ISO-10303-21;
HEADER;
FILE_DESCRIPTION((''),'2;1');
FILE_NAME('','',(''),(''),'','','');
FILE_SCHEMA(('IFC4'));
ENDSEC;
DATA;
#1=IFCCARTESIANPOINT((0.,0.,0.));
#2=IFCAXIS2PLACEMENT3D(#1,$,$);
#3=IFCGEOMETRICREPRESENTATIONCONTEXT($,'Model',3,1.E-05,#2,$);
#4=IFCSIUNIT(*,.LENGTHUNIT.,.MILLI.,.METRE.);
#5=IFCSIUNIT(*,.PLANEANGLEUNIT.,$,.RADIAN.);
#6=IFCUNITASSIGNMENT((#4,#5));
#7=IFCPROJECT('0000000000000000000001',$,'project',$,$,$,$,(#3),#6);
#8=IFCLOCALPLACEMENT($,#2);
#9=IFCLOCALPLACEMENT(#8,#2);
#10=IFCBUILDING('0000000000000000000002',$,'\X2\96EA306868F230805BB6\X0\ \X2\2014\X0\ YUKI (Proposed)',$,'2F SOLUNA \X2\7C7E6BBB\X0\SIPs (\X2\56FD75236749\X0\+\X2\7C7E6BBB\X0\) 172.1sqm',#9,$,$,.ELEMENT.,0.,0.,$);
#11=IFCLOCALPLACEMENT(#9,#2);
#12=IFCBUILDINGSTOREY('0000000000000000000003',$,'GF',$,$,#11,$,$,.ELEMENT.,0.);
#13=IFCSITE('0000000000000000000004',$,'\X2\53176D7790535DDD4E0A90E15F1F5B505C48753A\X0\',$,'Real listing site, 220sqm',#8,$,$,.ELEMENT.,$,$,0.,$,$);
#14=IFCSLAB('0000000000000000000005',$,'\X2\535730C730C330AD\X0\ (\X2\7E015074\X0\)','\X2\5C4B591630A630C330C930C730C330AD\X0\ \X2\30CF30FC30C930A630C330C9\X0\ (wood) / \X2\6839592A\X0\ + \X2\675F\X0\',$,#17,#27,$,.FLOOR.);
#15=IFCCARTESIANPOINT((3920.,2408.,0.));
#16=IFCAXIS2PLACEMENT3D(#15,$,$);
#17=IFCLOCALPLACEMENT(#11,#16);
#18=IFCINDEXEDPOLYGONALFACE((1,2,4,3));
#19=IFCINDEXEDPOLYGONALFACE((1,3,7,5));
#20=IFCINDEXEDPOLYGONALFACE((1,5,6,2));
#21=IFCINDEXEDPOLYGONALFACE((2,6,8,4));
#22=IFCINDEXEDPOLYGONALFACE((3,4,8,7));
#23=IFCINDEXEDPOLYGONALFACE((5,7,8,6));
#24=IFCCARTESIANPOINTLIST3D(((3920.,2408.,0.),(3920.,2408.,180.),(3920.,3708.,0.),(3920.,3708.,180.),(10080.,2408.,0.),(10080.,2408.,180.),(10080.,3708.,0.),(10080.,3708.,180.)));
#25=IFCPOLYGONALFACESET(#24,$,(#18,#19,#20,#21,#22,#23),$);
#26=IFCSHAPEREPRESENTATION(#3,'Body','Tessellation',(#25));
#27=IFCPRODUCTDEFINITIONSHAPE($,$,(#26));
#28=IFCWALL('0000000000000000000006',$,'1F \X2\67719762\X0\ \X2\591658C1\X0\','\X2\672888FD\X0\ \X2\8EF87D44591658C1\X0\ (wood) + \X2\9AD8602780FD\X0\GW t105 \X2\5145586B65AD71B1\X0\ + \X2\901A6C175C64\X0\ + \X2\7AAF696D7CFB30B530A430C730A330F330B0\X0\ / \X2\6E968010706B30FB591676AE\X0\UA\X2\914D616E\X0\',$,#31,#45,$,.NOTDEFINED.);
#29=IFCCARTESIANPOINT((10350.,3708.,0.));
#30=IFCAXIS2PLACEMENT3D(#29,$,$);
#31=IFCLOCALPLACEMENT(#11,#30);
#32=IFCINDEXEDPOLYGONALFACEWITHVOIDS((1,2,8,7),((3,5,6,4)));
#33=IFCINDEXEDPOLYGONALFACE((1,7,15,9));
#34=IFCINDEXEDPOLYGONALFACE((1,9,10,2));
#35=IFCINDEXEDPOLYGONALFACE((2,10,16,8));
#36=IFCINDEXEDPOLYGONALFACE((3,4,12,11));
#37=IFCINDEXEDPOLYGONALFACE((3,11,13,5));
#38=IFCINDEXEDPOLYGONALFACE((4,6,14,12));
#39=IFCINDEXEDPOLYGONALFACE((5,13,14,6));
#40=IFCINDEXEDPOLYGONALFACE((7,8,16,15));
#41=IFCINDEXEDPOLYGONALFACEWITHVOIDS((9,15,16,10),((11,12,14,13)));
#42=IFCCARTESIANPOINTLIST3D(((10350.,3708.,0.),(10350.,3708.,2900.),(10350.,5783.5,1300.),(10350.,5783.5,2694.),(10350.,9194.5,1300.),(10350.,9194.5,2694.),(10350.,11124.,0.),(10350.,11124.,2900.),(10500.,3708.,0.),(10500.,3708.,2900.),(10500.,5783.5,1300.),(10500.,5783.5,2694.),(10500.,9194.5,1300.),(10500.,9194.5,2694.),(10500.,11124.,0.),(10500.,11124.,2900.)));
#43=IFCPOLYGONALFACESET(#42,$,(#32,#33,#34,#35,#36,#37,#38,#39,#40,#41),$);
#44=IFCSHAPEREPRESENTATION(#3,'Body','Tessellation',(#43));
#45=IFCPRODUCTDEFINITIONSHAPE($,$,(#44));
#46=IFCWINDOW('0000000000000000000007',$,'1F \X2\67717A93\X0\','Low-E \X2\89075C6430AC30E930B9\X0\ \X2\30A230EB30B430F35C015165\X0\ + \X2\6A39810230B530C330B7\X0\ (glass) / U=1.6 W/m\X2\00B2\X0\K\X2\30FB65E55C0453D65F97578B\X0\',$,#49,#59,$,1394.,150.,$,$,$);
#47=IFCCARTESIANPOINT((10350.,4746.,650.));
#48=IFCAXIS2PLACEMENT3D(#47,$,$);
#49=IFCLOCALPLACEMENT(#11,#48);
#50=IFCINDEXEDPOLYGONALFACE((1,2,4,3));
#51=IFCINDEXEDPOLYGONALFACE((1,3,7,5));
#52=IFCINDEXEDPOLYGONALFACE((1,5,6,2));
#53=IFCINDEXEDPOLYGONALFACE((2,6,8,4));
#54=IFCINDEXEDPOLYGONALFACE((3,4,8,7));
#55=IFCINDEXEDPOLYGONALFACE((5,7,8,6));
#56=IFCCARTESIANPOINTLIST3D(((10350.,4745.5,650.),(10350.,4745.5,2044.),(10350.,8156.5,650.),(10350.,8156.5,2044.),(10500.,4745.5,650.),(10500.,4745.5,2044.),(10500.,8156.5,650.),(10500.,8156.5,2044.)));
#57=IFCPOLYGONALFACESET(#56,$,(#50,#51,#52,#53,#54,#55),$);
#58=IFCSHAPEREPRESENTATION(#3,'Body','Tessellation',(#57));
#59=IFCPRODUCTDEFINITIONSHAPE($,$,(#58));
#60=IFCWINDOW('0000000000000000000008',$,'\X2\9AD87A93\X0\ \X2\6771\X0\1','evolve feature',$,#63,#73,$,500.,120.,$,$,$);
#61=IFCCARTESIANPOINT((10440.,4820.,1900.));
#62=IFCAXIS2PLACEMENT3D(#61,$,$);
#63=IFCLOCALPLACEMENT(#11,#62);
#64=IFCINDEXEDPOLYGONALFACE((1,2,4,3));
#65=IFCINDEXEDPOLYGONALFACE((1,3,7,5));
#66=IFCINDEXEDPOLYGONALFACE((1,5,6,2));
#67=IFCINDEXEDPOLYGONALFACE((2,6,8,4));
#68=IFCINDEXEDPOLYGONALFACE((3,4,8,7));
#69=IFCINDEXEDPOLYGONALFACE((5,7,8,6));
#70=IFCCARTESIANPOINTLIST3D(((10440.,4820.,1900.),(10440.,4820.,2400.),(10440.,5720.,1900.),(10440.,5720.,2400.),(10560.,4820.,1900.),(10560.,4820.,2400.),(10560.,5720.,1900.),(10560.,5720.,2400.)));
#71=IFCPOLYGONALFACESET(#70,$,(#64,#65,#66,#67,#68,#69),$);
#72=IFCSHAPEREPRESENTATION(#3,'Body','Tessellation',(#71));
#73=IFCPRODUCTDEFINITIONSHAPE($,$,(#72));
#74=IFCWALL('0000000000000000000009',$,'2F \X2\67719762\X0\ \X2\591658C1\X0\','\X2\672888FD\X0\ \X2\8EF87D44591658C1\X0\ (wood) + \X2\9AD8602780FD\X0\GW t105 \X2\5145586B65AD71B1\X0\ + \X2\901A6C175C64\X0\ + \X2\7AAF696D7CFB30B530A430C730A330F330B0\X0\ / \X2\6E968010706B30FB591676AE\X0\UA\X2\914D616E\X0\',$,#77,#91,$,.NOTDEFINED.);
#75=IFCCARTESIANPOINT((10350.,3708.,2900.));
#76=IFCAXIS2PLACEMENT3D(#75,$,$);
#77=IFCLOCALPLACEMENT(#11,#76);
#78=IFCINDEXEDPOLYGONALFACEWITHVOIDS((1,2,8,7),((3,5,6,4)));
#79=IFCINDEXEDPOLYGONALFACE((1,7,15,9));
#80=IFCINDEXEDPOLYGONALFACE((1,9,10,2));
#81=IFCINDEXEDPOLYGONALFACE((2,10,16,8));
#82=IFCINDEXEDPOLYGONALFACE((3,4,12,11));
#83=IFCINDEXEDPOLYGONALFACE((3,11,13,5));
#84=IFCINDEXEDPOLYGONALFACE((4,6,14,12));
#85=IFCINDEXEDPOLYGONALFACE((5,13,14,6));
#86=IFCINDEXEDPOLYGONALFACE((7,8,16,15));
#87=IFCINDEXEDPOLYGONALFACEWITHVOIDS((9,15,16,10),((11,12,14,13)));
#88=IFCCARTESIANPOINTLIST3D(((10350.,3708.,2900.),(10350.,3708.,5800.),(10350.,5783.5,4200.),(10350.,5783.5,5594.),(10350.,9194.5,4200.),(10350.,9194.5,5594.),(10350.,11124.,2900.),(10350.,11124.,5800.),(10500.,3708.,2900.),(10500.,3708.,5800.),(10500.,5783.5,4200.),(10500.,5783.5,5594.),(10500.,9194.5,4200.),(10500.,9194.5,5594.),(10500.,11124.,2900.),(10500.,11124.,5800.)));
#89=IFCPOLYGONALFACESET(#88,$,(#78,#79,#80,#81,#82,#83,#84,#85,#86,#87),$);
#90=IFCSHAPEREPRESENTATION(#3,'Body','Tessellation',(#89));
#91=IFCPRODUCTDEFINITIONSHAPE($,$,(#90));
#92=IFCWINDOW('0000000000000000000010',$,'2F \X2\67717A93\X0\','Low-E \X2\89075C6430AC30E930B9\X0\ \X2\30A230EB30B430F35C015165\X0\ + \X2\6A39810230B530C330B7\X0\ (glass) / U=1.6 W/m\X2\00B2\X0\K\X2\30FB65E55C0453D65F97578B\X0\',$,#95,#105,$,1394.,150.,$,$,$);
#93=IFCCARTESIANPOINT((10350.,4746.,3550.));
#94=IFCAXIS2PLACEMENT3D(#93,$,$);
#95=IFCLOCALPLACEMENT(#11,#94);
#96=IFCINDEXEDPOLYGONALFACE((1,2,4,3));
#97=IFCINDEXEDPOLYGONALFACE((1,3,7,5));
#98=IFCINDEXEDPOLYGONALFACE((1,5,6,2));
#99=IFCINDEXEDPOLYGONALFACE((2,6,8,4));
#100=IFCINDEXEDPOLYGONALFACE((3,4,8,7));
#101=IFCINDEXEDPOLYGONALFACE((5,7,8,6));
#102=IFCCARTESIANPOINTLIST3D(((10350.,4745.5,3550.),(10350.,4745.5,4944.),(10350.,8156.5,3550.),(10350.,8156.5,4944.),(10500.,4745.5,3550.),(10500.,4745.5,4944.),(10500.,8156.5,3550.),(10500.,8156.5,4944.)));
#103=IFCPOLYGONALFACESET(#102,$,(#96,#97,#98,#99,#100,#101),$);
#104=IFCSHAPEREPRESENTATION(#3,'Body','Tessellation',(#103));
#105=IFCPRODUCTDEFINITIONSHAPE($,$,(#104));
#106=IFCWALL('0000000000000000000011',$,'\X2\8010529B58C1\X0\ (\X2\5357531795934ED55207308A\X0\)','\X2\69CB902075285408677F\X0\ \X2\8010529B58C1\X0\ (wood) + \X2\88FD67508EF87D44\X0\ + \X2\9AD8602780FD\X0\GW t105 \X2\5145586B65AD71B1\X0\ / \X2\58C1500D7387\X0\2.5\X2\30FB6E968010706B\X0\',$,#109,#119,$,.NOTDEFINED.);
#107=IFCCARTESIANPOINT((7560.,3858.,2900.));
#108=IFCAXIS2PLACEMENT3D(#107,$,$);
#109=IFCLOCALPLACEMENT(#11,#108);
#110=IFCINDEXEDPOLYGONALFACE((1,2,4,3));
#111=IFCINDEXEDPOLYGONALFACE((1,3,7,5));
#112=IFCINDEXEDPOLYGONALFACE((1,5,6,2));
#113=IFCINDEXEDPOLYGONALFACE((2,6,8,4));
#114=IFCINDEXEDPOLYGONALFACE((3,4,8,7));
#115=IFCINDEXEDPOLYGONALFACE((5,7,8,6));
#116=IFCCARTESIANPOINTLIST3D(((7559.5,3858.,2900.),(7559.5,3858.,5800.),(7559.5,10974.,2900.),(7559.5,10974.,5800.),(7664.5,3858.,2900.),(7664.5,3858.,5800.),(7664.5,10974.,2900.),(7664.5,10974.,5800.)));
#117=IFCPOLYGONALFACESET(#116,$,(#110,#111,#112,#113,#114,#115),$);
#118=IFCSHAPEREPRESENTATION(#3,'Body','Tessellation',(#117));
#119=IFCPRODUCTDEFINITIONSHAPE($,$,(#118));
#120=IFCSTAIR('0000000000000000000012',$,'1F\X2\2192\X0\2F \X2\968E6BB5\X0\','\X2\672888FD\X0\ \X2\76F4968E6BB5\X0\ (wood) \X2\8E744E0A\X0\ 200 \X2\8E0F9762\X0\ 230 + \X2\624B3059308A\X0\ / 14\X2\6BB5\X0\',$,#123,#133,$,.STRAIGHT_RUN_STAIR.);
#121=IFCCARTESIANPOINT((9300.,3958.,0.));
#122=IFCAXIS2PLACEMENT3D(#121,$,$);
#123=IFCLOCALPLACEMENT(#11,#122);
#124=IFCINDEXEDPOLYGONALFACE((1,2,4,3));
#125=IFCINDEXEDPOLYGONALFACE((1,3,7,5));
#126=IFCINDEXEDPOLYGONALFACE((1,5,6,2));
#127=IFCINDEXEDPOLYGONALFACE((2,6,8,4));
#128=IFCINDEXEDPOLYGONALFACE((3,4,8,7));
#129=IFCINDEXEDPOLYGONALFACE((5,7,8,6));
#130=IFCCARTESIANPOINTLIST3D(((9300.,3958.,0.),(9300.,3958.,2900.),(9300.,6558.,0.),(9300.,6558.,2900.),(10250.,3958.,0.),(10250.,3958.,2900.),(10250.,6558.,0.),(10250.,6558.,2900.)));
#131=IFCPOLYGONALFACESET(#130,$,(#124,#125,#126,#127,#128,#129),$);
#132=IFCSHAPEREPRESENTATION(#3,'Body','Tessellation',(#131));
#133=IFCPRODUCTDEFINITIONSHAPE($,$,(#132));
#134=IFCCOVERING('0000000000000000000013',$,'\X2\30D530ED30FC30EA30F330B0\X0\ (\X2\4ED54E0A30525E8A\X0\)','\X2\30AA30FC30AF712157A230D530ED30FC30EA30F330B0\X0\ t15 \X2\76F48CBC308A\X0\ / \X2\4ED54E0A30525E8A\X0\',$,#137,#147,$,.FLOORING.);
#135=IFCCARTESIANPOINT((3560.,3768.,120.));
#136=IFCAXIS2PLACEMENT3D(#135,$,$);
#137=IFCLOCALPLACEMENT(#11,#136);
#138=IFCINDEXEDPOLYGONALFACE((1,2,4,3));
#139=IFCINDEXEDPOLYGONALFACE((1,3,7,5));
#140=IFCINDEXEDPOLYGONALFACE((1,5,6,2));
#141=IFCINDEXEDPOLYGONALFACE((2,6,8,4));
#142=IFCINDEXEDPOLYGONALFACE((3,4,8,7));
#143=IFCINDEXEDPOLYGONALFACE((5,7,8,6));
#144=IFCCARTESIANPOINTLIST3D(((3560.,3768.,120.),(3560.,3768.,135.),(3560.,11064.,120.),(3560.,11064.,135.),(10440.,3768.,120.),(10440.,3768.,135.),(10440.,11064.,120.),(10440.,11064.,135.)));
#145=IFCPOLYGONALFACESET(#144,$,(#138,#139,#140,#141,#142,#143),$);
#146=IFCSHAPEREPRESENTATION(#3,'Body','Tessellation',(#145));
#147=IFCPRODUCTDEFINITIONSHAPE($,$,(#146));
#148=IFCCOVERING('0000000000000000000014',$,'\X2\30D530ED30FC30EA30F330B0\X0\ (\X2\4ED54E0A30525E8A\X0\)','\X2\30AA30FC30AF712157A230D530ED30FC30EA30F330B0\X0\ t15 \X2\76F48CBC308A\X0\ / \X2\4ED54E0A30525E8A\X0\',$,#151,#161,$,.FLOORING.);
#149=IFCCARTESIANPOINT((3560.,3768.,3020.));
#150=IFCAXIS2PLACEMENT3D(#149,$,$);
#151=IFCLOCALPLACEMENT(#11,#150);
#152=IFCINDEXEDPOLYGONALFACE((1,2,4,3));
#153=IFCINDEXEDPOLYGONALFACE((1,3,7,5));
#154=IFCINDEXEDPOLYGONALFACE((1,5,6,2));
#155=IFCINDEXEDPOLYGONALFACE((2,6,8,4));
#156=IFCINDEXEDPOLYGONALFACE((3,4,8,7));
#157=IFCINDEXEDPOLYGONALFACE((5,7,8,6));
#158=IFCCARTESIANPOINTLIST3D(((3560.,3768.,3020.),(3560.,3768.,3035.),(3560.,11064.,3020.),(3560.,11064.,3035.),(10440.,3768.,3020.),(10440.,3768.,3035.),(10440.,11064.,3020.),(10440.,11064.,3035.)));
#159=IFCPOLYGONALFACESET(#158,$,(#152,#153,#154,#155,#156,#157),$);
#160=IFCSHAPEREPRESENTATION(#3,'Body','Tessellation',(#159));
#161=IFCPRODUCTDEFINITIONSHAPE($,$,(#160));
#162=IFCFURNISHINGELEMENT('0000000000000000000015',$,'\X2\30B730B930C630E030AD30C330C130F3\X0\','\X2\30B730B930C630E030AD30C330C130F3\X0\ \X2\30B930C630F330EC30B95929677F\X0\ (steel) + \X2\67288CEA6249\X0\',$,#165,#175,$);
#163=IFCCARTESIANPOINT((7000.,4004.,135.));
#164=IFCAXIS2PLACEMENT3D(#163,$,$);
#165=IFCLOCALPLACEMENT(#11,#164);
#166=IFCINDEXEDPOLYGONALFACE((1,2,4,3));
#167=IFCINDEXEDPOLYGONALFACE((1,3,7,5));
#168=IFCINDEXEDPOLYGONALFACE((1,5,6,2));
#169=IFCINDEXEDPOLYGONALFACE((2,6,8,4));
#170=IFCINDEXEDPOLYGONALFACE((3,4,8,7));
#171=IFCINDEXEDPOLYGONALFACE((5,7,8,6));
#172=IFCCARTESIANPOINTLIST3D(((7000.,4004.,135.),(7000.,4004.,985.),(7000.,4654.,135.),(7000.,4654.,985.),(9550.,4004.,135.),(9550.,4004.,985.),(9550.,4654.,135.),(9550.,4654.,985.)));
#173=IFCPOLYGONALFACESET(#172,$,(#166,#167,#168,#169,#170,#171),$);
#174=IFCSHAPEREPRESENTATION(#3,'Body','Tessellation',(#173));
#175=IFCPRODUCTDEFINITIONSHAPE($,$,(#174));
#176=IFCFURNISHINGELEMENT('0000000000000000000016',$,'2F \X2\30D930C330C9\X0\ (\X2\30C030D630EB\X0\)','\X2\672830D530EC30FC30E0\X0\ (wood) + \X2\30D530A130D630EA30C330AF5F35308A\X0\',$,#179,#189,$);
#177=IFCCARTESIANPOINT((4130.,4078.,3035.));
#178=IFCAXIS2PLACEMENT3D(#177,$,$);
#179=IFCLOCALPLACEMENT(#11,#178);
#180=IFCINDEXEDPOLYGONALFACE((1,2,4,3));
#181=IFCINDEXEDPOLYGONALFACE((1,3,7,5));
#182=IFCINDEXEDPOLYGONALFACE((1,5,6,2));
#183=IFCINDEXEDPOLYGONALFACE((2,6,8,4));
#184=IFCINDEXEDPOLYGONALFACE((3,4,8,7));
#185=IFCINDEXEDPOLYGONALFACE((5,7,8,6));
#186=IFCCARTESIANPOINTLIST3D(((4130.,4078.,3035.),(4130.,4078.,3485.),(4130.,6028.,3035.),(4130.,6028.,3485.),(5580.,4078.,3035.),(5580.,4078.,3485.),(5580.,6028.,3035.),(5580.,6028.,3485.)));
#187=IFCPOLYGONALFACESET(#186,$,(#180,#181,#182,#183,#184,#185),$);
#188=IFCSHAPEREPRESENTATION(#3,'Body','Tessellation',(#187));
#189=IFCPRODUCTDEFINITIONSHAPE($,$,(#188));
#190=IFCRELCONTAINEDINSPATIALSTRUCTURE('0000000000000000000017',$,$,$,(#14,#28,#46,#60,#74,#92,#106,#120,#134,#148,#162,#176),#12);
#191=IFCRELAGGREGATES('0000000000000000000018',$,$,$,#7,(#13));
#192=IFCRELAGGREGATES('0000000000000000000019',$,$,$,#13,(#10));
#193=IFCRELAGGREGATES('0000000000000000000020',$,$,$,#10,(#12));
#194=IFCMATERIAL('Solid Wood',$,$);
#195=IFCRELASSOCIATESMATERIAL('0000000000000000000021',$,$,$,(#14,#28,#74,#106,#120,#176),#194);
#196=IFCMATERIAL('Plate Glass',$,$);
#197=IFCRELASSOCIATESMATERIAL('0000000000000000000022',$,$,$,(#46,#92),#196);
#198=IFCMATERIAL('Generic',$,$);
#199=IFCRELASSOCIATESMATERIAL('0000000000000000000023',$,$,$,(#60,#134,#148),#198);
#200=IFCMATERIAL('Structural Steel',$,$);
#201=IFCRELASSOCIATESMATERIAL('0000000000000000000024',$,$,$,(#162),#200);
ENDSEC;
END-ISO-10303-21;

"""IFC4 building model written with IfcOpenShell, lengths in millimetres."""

from ifc_helpers import new_model, si_unit, frame, frame_2d, origin, place, context, project, spatial, rectangle, extrude, material, element, fill, save


model = new_model("IFC4")

# Units and contexts
model_context = context("Model", 3, precision=1e-05, world=origin())
ifc_project = project(units=[si_unit("LENGTHUNIT", "METRE", prefix="MILLI"), si_unit("PLANEANGLEUNIT", "RADIAN")], contexts=[model_context])

# Site, building, storey
site_placement = place(None, origin())
site = spatial("IfcSite", under=ifc_project, at=site_placement, Name="北海道川上郡弟子屈町", ObjectType="Real listing site, 220sqm", CompositionType="ELEMENT", RefElevation=0.0)
building_placement = place(site_placement, origin())
building = spatial("IfcBuilding", under=site, at=building_placement, Name="雪と棲む家 — YUKI (Proposed)", ObjectType="2F SOLUNA 籾殻SIPs (国産杉+籾殻) 172.1sqm", CompositionType="ELEMENT", ElevationOfRefHeight=0.0, ElevationOfTerrain=0.0)
storey_placement = place(building_placement, origin())
storey = spatial("IfcBuildingStorey", under=building, at=storey_placement, Name="GF", CompositionType="ELEMENT", Elevation=0.0)

# Slab
ifc_material_1 = material(Name="Solid Wood")
slab_placement = place(storey_placement, frame((3920.0, 2408.0, 0.0)))
element("IfcSlab", 1, at=slab_placement, inside=storey, material=ifc_material_1, Name="南デッキ (縁側)", Description="屋外ウッドデッキ ハードウッド (wood) / 根太 + 束", PredefinedType="FLOOR", context=model_context, shape_type="SweptSolid", body=[
    extrude(rectangle(XDim=6160.0, YDim=1300.0, at=frame_2d((3080.0, 650.0))), frame((3920.0, 2408.0, 0.0)), (0.0, 0.0, 1.0), 180.0),
])

# Wall, openings, windows
wall_1_placement = place(storey_placement, frame((10350.0, 3708.0, 0.0)))
wall_1 = element("IfcWall", 2, at=wall_1_placement, inside=storey, material=ifc_material_1, Name="1F 東面 外壁", Description="木製 軸組外壁 (wood) + 高性能GW t105 充填断熱 + 通気層 + 窯業系サイディング / 準耐火・外皮UA配慮", PredefinedType="NOTDEFINED", context=model_context, shape_type="SweptSolid", body=[
    extrude(rectangle(XDim=150.0, YDim=7416.0, at=frame_2d((75.0, 3708.0))), frame((10350.0, 3708.0, 0.0)), (0.0, 0.0, 1.0), 2900.0),
])
opening_1_placement = place(storey_placement, frame((10350.0, 4746.0, 650.0)))
opening_1 = element("IfcOpeningElement", 3, at=opening_1_placement, cuts=wall_1, PredefinedType="NOTDEFINED", context=model_context, shape_type="SweptSolid", body=[
    extrude(rectangle(XDim=150.0, YDim=3411.0, at=frame_2d((75.0, 1705.0))), frame((10350.0, 4746.0, 650.0)), (0.0, 0.0, 1.0), 1394.0),
])
opening_2_placement = place(storey_placement, frame((10440.0, 4820.0, 1900.0)))
opening_2 = element("IfcOpeningElement", 4, at=opening_2_placement, cuts=wall_1, PredefinedType="NOTDEFINED", context=model_context, shape_type="SweptSolid", body=[
    extrude(rectangle(XDim=120.0, YDim=900.0, at=frame_2d((60.0, 450.0))), frame((10440.0, 4820.0, 1900.0)), (0.0, 0.0, 1.0), 500.0),
])
ifc_material_2 = material(Name="Plate Glass")
window_1_placement = place(storey_placement, frame((10350.0, 4746.0, 650.0)))
window_1 = element("IfcWindow", 5, at=window_1_placement, inside=storey, material=ifc_material_2, Name="1F 東窓", Description="Low-E 複層ガラス アルゴン封入 + 樹脂サッシ (glass) / U=1.6 W/m²K・日射取得型", OverallHeight=1394.0, OverallWidth=150.0, context=model_context, shape_type="SweptSolid", body=[
    extrude(rectangle(XDim=150.0, YDim=3411.0, at=frame_2d((75.0, 1705.0))), frame((10350.0, 4746.0, 650.0)), (0.0, 0.0, 1.0), 1394.0),
])
fill(opening_1, window_1)
ifc_material_3 = material(Name="Generic")
window_2_placement = place(storey_placement, frame((10440.0, 4820.0, 1900.0)))
window_2 = element("IfcWindow", 6, at=window_2_placement, inside=storey, material=ifc_material_3, Name="高窓 東1", Description="evolve feature", OverallHeight=500.0, OverallWidth=120.0, context=model_context, shape_type="SweptSolid", body=[
    extrude(rectangle(XDim=120.0, YDim=900.0, at=frame_2d((60.0, 450.0))), frame((10440.0, 4820.0, 1900.0)), (0.0, 0.0, 1.0), 500.0),
])
fill(opening_2, window_2)

# Wall, opening, window
wall_2_placement = place(storey_placement, frame((10350.0, 3708.0, 2900.0)))
wall_2 = element("IfcWall", 7, at=wall_2_placement, inside=storey, material=ifc_material_1, Name="2F 東面 外壁", Description="木製 軸組外壁 (wood) + 高性能GW t105 充填断熱 + 通気層 + 窯業系サイディング / 準耐火・外皮UA配慮", PredefinedType="NOTDEFINED", context=model_context, shape_type="SweptSolid", body=[
    extrude(rectangle(XDim=150.0, YDim=7416.0, at=frame_2d((75.0, 3708.0))), frame((10350.0, 3708.0, 2900.0)), (0.0, 0.0, 1.0), 2900.0),
])
opening_3_placement = place(storey_placement, frame((10350.0, 4746.0, 3550.0)))
opening_3 = element("IfcOpeningElement", 8, at=opening_3_placement, cuts=wall_2, PredefinedType="NOTDEFINED", context=model_context, shape_type="SweptSolid", body=[
    extrude(rectangle(XDim=150.0, YDim=3411.0, at=frame_2d((75.0, 1705.0))), frame((10350.0, 4746.0, 3550.0)), (0.0, 0.0, 1.0), 1394.0),
])
window_3_placement = place(storey_placement, frame((10350.0, 4746.0, 3550.0)))
window_3 = element("IfcWindow", 9, at=window_3_placement, inside=storey, material=ifc_material_2, Name="2F 東窓", Description="Low-E 複層ガラス アルゴン封入 + 樹脂サッシ (glass) / U=1.6 W/m²K・日射取得型", OverallHeight=1394.0, OverallWidth=150.0, context=model_context, shape_type="SweptSolid", body=[
    extrude(rectangle(XDim=150.0, YDim=3411.0, at=frame_2d((75.0, 1705.0))), frame((10350.0, 4746.0, 3550.0)), (0.0, 0.0, 1.0), 1394.0),
])
fill(opening_3, window_3)

# Wall
wall_3_placement = place(storey_placement, frame((7560.0, 3858.0, 2900.0)))
element("IfcWall", 10, at=wall_3_placement, inside=storey, material=ifc_material_1, Name="耐力壁 (南北間仕切り)", Description="構造用合板 耐力壁 (wood) + 製材軸組 + 高性能GW t105 充填断熱 / 壁倍率2.5・準耐火", PredefinedType="NOTDEFINED", context=model_context, shape_type="SweptSolid", body=[
    extrude(rectangle(XDim=105.0, YDim=7116.0, at=frame_2d((52.0, 3558.0))), frame((7560.0, 3858.0, 2900.0)), (0.0, 0.0, 1.0), 2900.0),
])

# Stair
stair_placement = place(storey_placement, frame((9300.0, 3958.0, 0.0)))
element("IfcStair", 11, at=stair_placement, inside=storey, material=ifc_material_1, Name="1F→2F 階段", Description="木製 直階段 (wood) 蹴上 200 踏面 230 + 手すり / 14段", PredefinedType="STRAIGHT_RUN_STAIR", context=model_context, shape_type="SweptSolid", body=[
    extrude(rectangle(XDim=950.0, YDim=2600.0, at=frame_2d((475.0, 1300.0))), frame((9300.0, 3958.0, 0.0)), (0.0, 0.0, 1.0), 2900.0),
])

# Coverings
covering_1_placement = place(storey_placement, frame((3560.0, 3768.0, 120.0)))
element("IfcCovering", 12, at=covering_1_placement, inside=storey, material=ifc_material_3, Name="フローリング (仕上げ床)", Description="オーク無垢フローリング t15 直貼り / 仕上げ床", PredefinedType="FLOORING", context=model_context, shape_type="SweptSolid", body=[
    extrude(rectangle(XDim=6880.0, YDim=7296.0, at=frame_2d((3440.0, 3648.0))), frame((3560.0, 3768.0, 120.0)), (0.0, 0.0, 1.0), 15.0),
])
covering_2_placement = place(storey_placement, frame((3560.0, 3768.0, 3020.0)))
element("IfcCovering", 13, at=covering_2_placement, inside=storey, material=ifc_material_3, Name="フローリング (仕上げ床)", Description="オーク無垢フローリング t15 直貼り / 仕上げ床", PredefinedType="FLOORING", context=model_context, shape_type="SweptSolid", body=[
    extrude(rectangle(XDim=6880.0, YDim=7296.0, at=frame_2d((3440.0, 3648.0))), frame((3560.0, 3768.0, 3020.0)), (0.0, 0.0, 1.0), 15.0),
])

# Furnishing elements
ifc_material_4 = material(Name="Structural Steel")
furnishing_1_placement = place(storey_placement, frame((7000.0, 4004.0, 135.0)))
element("IfcFurnishingElement", 14, at=furnishing_1_placement, inside=storey, material=ifc_material_4, Name="システムキッチン", Description="システムキッチン ステンレス天板 (steel) + 木質扉", context=model_context, shape_type="SweptSolid", body=[
    extrude(rectangle(XDim=2550.0, YDim=650.0, at=frame_2d((1275.0, 325.0))), frame((7000.0, 4004.0, 135.0)), (0.0, 0.0, 1.0), 850.0),
])
furnishing_2_placement = place(storey_placement, frame((4130.0, 4078.0, 3035.0)))
element("IfcFurnishingElement", 15, at=furnishing_2_placement, inside=storey, material=ifc_material_1, Name="2F ベッド (ダブル)", Description="木フレーム (wood) + ファブリック張り", context=model_context, shape_type="SweptSolid", body=[
    extrude(rectangle(XDim=1450.0, YDim=1950.0, at=frame_2d((725.0, 975.0))), frame((4130.0, 4078.0, 3035.0)), (0.0, 0.0, 1.0), 450.0),
])

save(model, "model.ifc")
